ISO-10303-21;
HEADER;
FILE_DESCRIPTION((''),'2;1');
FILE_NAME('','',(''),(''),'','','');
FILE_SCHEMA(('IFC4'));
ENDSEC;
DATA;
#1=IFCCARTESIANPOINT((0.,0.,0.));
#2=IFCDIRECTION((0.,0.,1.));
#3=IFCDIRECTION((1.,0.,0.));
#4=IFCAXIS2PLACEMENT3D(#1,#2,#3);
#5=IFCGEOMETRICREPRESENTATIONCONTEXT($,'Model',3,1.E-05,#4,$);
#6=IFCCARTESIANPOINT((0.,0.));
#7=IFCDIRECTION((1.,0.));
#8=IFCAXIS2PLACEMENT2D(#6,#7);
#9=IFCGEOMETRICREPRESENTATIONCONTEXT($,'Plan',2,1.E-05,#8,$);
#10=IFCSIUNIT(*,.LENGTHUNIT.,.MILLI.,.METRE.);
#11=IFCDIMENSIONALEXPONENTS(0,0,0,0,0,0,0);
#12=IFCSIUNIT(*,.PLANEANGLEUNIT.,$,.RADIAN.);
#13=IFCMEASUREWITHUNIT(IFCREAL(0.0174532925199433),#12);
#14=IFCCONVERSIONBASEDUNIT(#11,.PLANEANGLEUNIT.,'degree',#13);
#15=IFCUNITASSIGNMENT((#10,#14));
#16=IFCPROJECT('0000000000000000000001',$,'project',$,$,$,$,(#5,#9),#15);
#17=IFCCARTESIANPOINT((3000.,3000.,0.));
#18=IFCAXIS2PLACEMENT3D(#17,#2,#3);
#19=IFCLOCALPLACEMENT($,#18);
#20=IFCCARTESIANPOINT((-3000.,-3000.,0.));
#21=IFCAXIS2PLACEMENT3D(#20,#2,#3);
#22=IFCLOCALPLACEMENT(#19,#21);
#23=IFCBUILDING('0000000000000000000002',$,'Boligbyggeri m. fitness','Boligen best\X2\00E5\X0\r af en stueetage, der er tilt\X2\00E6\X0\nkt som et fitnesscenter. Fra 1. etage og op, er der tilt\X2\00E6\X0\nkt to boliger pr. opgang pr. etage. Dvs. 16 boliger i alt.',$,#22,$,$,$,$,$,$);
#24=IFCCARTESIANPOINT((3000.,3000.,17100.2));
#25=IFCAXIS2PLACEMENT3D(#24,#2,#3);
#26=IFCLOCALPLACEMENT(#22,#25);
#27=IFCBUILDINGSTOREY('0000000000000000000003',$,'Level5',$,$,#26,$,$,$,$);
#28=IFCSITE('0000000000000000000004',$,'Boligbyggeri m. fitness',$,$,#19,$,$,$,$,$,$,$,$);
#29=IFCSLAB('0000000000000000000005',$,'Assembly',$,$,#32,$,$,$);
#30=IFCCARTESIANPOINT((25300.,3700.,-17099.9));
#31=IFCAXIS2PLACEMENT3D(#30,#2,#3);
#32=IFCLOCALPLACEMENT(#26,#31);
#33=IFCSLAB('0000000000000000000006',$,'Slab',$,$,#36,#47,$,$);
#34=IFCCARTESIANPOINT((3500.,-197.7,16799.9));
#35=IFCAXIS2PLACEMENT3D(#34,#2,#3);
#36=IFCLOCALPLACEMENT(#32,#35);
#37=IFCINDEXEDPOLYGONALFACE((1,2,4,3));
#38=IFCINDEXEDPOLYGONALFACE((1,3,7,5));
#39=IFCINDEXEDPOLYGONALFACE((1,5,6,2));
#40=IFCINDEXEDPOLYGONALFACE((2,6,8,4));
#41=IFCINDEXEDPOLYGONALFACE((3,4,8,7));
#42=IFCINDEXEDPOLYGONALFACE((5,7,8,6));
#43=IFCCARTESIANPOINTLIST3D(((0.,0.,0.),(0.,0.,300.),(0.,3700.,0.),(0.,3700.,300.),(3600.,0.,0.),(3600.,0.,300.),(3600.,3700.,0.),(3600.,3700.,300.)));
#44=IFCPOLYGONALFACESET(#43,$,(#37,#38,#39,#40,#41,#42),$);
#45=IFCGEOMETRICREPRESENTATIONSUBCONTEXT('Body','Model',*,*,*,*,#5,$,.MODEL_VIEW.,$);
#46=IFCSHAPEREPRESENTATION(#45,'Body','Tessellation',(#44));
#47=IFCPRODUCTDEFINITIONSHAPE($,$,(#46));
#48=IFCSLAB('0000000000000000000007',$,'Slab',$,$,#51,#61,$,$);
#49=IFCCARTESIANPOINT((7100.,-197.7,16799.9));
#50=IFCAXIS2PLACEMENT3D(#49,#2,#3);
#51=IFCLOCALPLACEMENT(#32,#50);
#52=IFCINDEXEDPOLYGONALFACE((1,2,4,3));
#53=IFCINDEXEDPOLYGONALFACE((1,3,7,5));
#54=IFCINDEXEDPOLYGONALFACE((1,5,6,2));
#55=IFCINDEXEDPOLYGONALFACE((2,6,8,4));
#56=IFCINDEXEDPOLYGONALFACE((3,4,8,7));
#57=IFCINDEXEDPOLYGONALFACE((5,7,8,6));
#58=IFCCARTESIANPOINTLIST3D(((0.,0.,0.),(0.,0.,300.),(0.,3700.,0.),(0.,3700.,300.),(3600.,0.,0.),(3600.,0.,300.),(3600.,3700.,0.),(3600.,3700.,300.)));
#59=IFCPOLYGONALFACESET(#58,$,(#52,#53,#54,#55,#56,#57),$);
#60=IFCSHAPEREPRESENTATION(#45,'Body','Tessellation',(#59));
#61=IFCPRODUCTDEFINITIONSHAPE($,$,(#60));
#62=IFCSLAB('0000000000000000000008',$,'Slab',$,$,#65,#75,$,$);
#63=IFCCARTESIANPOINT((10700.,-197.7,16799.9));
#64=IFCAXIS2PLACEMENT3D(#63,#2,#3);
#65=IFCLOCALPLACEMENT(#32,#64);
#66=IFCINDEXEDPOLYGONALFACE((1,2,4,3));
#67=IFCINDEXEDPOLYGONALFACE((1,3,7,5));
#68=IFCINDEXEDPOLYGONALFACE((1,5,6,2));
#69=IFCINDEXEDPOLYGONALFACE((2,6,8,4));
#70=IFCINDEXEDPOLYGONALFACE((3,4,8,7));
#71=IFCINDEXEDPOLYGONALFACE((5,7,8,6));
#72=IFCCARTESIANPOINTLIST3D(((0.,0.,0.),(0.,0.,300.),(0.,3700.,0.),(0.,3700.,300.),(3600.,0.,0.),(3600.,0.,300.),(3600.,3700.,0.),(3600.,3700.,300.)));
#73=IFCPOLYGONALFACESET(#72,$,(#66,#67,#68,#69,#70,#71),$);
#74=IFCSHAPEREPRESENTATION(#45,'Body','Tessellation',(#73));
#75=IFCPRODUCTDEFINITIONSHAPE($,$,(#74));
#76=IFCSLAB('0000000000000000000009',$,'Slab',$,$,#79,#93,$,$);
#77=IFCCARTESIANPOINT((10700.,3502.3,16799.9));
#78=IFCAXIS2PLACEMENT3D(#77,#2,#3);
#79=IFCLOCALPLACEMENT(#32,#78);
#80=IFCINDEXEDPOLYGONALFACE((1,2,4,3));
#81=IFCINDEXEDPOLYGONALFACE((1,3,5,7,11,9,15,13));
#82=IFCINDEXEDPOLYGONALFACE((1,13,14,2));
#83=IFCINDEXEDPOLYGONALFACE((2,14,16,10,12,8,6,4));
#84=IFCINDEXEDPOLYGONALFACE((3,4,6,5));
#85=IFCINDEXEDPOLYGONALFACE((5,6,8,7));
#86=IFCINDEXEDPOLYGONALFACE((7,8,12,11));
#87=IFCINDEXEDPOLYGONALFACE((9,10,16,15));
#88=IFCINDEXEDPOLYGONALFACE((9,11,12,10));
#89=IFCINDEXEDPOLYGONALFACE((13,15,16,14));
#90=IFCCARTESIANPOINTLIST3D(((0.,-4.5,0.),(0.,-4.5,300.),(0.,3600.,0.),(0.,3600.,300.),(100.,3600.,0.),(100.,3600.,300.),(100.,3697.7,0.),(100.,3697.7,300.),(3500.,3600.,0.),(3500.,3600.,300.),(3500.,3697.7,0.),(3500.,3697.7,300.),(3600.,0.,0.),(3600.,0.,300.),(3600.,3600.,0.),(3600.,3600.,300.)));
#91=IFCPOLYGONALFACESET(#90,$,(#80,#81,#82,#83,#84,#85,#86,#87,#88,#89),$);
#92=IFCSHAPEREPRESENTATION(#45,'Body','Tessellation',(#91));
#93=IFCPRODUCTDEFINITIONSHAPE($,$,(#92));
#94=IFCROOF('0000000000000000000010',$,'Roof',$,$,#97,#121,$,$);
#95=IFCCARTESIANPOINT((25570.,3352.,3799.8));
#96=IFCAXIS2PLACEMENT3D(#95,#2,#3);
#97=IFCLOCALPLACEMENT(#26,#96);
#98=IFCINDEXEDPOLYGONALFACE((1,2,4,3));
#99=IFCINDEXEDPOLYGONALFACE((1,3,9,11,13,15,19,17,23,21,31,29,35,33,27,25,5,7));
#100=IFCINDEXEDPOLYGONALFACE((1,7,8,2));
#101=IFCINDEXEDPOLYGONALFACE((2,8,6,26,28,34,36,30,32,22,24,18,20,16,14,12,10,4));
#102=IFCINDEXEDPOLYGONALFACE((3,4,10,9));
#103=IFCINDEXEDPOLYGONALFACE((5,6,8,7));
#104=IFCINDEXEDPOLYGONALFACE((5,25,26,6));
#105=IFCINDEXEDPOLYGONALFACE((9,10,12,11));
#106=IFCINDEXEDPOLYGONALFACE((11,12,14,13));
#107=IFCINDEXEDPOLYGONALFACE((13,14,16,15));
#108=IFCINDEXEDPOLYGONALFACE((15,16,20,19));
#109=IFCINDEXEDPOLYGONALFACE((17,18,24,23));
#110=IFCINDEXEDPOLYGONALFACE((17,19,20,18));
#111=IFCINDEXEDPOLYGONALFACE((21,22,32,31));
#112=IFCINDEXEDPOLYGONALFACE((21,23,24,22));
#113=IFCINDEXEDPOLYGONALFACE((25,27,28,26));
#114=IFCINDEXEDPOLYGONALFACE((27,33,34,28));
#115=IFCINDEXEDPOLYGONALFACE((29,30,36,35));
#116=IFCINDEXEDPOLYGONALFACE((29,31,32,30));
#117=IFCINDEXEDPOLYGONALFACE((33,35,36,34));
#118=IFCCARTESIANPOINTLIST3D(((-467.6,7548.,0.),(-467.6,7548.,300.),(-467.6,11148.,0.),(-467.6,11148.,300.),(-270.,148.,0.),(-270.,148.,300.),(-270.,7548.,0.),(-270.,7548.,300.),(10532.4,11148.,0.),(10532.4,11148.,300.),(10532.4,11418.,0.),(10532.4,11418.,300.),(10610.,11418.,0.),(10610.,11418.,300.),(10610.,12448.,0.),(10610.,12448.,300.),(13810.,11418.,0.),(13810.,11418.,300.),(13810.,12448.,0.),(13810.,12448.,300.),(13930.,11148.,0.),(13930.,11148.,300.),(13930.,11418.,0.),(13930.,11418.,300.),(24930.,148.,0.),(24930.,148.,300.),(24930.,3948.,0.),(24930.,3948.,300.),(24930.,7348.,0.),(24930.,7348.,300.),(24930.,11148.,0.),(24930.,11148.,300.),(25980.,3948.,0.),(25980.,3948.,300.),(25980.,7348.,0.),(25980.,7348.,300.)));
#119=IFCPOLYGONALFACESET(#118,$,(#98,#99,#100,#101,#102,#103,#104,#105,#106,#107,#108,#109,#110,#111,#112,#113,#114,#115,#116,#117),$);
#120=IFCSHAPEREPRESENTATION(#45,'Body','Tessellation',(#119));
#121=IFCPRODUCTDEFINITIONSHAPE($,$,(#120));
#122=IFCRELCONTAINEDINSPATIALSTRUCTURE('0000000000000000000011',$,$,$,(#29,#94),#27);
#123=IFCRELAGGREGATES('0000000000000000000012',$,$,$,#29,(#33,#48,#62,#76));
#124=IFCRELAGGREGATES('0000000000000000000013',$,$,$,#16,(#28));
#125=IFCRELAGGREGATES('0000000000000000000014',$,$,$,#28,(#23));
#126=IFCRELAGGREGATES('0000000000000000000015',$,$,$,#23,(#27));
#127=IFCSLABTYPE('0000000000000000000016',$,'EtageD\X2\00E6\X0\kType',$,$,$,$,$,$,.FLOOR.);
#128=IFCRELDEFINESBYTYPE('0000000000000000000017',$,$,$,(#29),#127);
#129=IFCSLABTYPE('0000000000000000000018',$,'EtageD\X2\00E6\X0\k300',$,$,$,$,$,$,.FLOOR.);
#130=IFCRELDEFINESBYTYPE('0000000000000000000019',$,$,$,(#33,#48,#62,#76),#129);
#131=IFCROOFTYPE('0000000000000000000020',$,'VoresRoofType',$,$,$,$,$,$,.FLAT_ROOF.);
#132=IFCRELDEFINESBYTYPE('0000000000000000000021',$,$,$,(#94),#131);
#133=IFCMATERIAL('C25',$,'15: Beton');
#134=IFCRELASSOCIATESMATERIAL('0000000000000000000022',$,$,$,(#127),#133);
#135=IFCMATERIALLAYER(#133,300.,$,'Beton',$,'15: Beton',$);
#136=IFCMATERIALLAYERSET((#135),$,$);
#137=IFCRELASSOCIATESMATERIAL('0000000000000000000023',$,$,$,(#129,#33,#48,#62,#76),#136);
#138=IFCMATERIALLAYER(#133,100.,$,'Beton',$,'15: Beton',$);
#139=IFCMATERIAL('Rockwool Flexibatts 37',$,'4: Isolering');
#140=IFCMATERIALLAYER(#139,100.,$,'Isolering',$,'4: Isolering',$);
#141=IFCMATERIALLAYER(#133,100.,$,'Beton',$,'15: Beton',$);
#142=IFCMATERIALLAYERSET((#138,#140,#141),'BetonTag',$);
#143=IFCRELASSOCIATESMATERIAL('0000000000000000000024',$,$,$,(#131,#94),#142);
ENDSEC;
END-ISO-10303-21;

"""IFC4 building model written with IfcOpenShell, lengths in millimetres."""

from ifc_helpers import new_model, entity, si_unit, converted_unit, frame, origin_with_axes, origin_2d_with_axis, place, context, subcontext, project, spatial, line, indexed_curve, outline, extrude, material, layer, layer_set, layer_usage, type_object, element, aggregate, save


model = new_model("IFC4")

# Units and contexts
model_context = context("Model", 3, precision=1e-05, world=origin_with_axes())
plan_context = context("Plan", 2, precision=1e-05, world=origin_2d_with_axis())
body_context = subcontext(model_context, "Body", "Model", "MODEL_VIEW")
ifc_project = project(units=[si_unit("LENGTHUNIT", "METRE", prefix="MILLI"), converted_unit("PLANEANGLEUNIT", "degree", entity("IfcReal", 0.0174532925199433), si_unit("PLANEANGLEUNIT", "RADIAN"), dimensions=[0, 0, 0, 0, 0, 0, 0])], contexts=[model_context, plan_context])

# Site, building, storey
site_placement = place(None, frame((3000.0, 3000.0, 0.0), z_axis=(0.0, 0.0, 1.0), x_axis=(1.0, 0.0, 0.0)))
site = spatial("IfcSite", under=ifc_project, at=site_placement, Name="Boligbyggeri m. fitness")
building_placement = place(site_placement, frame((-3000.0, -3000.0, 0.0), z_axis=(0.0, 0.0, 1.0), x_axis=(1.0, 0.0, 0.0)))
building = spatial("IfcBuilding", under=site, at=building_placement, Name="Boligbyggeri m. fitness", Description="Boligen består af en stueetage, der er tiltænkt som et fitnesscenter. Fra 1. etage og op, er der tiltænkt to boliger pr. opgang pr. etage. Dvs. 16 boliger i alt.")
storey_placement = place(building_placement, frame((3000.0, 3000.0, 17100.2), z_axis=(0.0, 0.0, 1.0), x_axis=(1.0, 0.0, 0.0)))
storey = spatial("IfcBuildingStorey", under=building, at=storey_placement, Name="Level5")

# Shared definitions
ifc_material_1 = material(Name="C25", Category="15: Beton")

# Slabs
slab_type_1 = type_object("IfcSlabType", Name="EtageDækType", PredefinedType="FLOOR", material=ifc_material_1)
slab_1_placement = place(storey_placement, frame((25300.0, 3700.0, -17099.9), z_axis=(0.0, 0.0, 1.0), x_axis=(1.0, 0.0, 0.0)))
slab_1 = element("IfcSlab", 1, at=slab_1_placement, inside=storey, type_object=slab_type_1, Name="Assembly")
ifc_layer_1 = layer(ifc_material_1, 300.0, Name="Beton", Category="15: Beton")
ifc_layer_set_1 = layer_set([ifc_layer_1])
ifc_layer_usage_1 = layer_usage(ifc_layer_set_1, "AXIS3", "POSITIVE", 0.0)
slab_type_2 = type_object("IfcSlabType", Name="EtageDæk300", PredefinedType="FLOOR", material=ifc_layer_set_1)
slab_2_placement = place(slab_1_placement, frame((3500.0, -197.7, 16799.9), z_axis=(0.0, 0.0, 1.0), x_axis=(1.0, 0.0, 0.0)))
slab_2 = element("IfcSlab", 2, at=slab_2_placement, type_object=slab_type_2, material=ifc_layer_usage_1, Name="Slab", context=body_context, shape_type="SweptSolid", body=[
    extrude(outline(indexed_curve([(0.0, 0.0), (3600.0, 0.0), (3600.0, 3700.0), (0.0, 3700.0)], segments=[line(3, 2), line(2, 1), line(1, 4), line(4, 3)], self_intersect=False)), None, (0.0, 0.0, 1.0), 300.0),
])
ifc_layer_usage_2 = layer_usage(ifc_layer_set_1, "AXIS3", "POSITIVE", 0.0)
slab_3_placement = place(slab_1_placement, frame((7100.0, -197.7, 16799.9), z_axis=(0.0, 0.0, 1.0), x_axis=(1.0, 0.0, 0.0)))
slab_3 = element("IfcSlab", 3, at=slab_3_placement, type_object=slab_type_2, material=ifc_layer_usage_2, Name="Slab", context=body_context, shape_type="SweptSolid", body=[
    extrude(outline(indexed_curve([(0.0, 0.0), (3600.0, 0.0), (3600.0, 3700.0), (0.0, 3700.0)], segments=[line(3, 2), line(2, 1), line(1, 4), line(4, 3)], self_intersect=False)), None, (0.0, 0.0, 1.0), 300.0),
])
ifc_layer_usage_3 = layer_usage(ifc_layer_set_1, "AXIS3", "POSITIVE", 0.0)
slab_4_placement = place(slab_1_placement, frame((10700.0, -197.7, 16799.9), z_axis=(0.0, 0.0, 1.0), x_axis=(1.0, 0.0, 0.0)))
slab_4 = element("IfcSlab", 4, at=slab_4_placement, type_object=slab_type_2, material=ifc_layer_usage_3, Name="Slab", context=body_context, shape_type="SweptSolid", body=[
    extrude(outline(indexed_curve([(0.0, 0.0), (3600.0, 0.0), (3600.0, 3700.0), (0.0, 3700.0)], segments=[line(3, 2), line(2, 1), line(1, 4), line(4, 3)], self_intersect=False)), None, (0.0, 0.0, 1.0), 300.0),
])
ifc_layer_usage_4 = layer_usage(ifc_layer_set_1, "AXIS3", "POSITIVE", 0.0)
slab_5_placement = place(slab_1_placement, frame((10700.0, 3502.3, 16799.9), z_axis=(0.0, 0.0, 1.0), x_axis=(1.0, 0.0, 0.0)))
slab_5 = element("IfcSlab", 5, at=slab_5_placement, type_object=slab_type_2, material=ifc_layer_usage_4, Name="Slab", context=body_context, shape_type="SweptSolid", body=[
    extrude(outline(indexed_curve([(100.0, 3697.7), (3500.0, 3697.7), (3500.0, 3600.0), (3600.0, 3600.0), (3600.0, 0.0), (0.0, -4.5), (0.0, 3600.0), (100.0, 3600.0)], segments=[line(5, 6), line(6, 7), line(7, 8), line(8, 1), line(1, 2), line(2, 3), line(3, 4), line(4, 5)], self_intersect=False)), None, (0.0, 0.0, 1.0), 300.0),
])
aggregate(slab_1, [slab_2, slab_3, slab_4, slab_5])

# Shared definitions
ifc_material_2 = material(Name="Rockwool Flexibatts 37", Category="4: Isolering")

# Roof
ifc_layer_2 = layer(ifc_material_1, 100.0, Name="Beton", Category="15: Beton")
ifc_layer_3 = layer(ifc_material_2, 100.0, Name="Isolering", Category="4: Isolering")
ifc_layer_4 = layer(ifc_material_1, 100.0, Name="Beton", Category="15: Beton")
ifc_layer_set_2 = layer_set([ifc_layer_2, ifc_layer_3, ifc_layer_4], Name="BetonTag")
ifc_layer_usage_5 = layer_usage(ifc_layer_set_2, "AXIS3", "POSITIVE", 0.0)
roof_type_1 = type_object("IfcRoofType", Name="VoresRoofType", PredefinedType="FLAT_ROOF", material=ifc_layer_set_2)
roof_1_placement = place(storey_placement, frame((25570.0, 3352.0, 3799.8), z_axis=(0.0, 0.0, 1.0), x_axis=(1.0, 0.0, 0.0)))
element("IfcRoof", 6, at=roof_1_placement, inside=storey, type_object=roof_type_1, material=ifc_layer_usage_5, Name="Roof", context=body_context, shape_type="SweptSolid", body=[
    extrude(outline(indexed_curve([(24930.0, 3948.0), (25980.0, 3948.0), (25980.0, 7348.0), (24930.0, 7348.0), (24930.0, 11148.0), (13930.0, 11148.0), (13930.0, 11418.0), (13810.0, 11418.0), (13810.0, 12448.0), (10610.0, 12448.0), (10610.0, 11418.0), (10532.4, 11418.0), (10532.4, 11148.0), (-467.6, 11148.0), (-467.6, 7548.0), (-270.0, 7548.0), (-270.0, 148.0), (24930.0, 148.0)], segments=[line(16, 15), line(15, 14), line(14, 13), line(13, 12), line(12, 11), line(11, 10), line(10, 9), line(9, 8), line(8, 7), line(7, 6), line(6, 5), line(5, 4), line(4, 3), line(3, 2), line(2, 1), line(1, 18), line(18, 17), line(17, 16)], self_intersect=False)), None, (0.0, 0.0, 1.0), 300.0),
])

save(model, "model.ifc")
